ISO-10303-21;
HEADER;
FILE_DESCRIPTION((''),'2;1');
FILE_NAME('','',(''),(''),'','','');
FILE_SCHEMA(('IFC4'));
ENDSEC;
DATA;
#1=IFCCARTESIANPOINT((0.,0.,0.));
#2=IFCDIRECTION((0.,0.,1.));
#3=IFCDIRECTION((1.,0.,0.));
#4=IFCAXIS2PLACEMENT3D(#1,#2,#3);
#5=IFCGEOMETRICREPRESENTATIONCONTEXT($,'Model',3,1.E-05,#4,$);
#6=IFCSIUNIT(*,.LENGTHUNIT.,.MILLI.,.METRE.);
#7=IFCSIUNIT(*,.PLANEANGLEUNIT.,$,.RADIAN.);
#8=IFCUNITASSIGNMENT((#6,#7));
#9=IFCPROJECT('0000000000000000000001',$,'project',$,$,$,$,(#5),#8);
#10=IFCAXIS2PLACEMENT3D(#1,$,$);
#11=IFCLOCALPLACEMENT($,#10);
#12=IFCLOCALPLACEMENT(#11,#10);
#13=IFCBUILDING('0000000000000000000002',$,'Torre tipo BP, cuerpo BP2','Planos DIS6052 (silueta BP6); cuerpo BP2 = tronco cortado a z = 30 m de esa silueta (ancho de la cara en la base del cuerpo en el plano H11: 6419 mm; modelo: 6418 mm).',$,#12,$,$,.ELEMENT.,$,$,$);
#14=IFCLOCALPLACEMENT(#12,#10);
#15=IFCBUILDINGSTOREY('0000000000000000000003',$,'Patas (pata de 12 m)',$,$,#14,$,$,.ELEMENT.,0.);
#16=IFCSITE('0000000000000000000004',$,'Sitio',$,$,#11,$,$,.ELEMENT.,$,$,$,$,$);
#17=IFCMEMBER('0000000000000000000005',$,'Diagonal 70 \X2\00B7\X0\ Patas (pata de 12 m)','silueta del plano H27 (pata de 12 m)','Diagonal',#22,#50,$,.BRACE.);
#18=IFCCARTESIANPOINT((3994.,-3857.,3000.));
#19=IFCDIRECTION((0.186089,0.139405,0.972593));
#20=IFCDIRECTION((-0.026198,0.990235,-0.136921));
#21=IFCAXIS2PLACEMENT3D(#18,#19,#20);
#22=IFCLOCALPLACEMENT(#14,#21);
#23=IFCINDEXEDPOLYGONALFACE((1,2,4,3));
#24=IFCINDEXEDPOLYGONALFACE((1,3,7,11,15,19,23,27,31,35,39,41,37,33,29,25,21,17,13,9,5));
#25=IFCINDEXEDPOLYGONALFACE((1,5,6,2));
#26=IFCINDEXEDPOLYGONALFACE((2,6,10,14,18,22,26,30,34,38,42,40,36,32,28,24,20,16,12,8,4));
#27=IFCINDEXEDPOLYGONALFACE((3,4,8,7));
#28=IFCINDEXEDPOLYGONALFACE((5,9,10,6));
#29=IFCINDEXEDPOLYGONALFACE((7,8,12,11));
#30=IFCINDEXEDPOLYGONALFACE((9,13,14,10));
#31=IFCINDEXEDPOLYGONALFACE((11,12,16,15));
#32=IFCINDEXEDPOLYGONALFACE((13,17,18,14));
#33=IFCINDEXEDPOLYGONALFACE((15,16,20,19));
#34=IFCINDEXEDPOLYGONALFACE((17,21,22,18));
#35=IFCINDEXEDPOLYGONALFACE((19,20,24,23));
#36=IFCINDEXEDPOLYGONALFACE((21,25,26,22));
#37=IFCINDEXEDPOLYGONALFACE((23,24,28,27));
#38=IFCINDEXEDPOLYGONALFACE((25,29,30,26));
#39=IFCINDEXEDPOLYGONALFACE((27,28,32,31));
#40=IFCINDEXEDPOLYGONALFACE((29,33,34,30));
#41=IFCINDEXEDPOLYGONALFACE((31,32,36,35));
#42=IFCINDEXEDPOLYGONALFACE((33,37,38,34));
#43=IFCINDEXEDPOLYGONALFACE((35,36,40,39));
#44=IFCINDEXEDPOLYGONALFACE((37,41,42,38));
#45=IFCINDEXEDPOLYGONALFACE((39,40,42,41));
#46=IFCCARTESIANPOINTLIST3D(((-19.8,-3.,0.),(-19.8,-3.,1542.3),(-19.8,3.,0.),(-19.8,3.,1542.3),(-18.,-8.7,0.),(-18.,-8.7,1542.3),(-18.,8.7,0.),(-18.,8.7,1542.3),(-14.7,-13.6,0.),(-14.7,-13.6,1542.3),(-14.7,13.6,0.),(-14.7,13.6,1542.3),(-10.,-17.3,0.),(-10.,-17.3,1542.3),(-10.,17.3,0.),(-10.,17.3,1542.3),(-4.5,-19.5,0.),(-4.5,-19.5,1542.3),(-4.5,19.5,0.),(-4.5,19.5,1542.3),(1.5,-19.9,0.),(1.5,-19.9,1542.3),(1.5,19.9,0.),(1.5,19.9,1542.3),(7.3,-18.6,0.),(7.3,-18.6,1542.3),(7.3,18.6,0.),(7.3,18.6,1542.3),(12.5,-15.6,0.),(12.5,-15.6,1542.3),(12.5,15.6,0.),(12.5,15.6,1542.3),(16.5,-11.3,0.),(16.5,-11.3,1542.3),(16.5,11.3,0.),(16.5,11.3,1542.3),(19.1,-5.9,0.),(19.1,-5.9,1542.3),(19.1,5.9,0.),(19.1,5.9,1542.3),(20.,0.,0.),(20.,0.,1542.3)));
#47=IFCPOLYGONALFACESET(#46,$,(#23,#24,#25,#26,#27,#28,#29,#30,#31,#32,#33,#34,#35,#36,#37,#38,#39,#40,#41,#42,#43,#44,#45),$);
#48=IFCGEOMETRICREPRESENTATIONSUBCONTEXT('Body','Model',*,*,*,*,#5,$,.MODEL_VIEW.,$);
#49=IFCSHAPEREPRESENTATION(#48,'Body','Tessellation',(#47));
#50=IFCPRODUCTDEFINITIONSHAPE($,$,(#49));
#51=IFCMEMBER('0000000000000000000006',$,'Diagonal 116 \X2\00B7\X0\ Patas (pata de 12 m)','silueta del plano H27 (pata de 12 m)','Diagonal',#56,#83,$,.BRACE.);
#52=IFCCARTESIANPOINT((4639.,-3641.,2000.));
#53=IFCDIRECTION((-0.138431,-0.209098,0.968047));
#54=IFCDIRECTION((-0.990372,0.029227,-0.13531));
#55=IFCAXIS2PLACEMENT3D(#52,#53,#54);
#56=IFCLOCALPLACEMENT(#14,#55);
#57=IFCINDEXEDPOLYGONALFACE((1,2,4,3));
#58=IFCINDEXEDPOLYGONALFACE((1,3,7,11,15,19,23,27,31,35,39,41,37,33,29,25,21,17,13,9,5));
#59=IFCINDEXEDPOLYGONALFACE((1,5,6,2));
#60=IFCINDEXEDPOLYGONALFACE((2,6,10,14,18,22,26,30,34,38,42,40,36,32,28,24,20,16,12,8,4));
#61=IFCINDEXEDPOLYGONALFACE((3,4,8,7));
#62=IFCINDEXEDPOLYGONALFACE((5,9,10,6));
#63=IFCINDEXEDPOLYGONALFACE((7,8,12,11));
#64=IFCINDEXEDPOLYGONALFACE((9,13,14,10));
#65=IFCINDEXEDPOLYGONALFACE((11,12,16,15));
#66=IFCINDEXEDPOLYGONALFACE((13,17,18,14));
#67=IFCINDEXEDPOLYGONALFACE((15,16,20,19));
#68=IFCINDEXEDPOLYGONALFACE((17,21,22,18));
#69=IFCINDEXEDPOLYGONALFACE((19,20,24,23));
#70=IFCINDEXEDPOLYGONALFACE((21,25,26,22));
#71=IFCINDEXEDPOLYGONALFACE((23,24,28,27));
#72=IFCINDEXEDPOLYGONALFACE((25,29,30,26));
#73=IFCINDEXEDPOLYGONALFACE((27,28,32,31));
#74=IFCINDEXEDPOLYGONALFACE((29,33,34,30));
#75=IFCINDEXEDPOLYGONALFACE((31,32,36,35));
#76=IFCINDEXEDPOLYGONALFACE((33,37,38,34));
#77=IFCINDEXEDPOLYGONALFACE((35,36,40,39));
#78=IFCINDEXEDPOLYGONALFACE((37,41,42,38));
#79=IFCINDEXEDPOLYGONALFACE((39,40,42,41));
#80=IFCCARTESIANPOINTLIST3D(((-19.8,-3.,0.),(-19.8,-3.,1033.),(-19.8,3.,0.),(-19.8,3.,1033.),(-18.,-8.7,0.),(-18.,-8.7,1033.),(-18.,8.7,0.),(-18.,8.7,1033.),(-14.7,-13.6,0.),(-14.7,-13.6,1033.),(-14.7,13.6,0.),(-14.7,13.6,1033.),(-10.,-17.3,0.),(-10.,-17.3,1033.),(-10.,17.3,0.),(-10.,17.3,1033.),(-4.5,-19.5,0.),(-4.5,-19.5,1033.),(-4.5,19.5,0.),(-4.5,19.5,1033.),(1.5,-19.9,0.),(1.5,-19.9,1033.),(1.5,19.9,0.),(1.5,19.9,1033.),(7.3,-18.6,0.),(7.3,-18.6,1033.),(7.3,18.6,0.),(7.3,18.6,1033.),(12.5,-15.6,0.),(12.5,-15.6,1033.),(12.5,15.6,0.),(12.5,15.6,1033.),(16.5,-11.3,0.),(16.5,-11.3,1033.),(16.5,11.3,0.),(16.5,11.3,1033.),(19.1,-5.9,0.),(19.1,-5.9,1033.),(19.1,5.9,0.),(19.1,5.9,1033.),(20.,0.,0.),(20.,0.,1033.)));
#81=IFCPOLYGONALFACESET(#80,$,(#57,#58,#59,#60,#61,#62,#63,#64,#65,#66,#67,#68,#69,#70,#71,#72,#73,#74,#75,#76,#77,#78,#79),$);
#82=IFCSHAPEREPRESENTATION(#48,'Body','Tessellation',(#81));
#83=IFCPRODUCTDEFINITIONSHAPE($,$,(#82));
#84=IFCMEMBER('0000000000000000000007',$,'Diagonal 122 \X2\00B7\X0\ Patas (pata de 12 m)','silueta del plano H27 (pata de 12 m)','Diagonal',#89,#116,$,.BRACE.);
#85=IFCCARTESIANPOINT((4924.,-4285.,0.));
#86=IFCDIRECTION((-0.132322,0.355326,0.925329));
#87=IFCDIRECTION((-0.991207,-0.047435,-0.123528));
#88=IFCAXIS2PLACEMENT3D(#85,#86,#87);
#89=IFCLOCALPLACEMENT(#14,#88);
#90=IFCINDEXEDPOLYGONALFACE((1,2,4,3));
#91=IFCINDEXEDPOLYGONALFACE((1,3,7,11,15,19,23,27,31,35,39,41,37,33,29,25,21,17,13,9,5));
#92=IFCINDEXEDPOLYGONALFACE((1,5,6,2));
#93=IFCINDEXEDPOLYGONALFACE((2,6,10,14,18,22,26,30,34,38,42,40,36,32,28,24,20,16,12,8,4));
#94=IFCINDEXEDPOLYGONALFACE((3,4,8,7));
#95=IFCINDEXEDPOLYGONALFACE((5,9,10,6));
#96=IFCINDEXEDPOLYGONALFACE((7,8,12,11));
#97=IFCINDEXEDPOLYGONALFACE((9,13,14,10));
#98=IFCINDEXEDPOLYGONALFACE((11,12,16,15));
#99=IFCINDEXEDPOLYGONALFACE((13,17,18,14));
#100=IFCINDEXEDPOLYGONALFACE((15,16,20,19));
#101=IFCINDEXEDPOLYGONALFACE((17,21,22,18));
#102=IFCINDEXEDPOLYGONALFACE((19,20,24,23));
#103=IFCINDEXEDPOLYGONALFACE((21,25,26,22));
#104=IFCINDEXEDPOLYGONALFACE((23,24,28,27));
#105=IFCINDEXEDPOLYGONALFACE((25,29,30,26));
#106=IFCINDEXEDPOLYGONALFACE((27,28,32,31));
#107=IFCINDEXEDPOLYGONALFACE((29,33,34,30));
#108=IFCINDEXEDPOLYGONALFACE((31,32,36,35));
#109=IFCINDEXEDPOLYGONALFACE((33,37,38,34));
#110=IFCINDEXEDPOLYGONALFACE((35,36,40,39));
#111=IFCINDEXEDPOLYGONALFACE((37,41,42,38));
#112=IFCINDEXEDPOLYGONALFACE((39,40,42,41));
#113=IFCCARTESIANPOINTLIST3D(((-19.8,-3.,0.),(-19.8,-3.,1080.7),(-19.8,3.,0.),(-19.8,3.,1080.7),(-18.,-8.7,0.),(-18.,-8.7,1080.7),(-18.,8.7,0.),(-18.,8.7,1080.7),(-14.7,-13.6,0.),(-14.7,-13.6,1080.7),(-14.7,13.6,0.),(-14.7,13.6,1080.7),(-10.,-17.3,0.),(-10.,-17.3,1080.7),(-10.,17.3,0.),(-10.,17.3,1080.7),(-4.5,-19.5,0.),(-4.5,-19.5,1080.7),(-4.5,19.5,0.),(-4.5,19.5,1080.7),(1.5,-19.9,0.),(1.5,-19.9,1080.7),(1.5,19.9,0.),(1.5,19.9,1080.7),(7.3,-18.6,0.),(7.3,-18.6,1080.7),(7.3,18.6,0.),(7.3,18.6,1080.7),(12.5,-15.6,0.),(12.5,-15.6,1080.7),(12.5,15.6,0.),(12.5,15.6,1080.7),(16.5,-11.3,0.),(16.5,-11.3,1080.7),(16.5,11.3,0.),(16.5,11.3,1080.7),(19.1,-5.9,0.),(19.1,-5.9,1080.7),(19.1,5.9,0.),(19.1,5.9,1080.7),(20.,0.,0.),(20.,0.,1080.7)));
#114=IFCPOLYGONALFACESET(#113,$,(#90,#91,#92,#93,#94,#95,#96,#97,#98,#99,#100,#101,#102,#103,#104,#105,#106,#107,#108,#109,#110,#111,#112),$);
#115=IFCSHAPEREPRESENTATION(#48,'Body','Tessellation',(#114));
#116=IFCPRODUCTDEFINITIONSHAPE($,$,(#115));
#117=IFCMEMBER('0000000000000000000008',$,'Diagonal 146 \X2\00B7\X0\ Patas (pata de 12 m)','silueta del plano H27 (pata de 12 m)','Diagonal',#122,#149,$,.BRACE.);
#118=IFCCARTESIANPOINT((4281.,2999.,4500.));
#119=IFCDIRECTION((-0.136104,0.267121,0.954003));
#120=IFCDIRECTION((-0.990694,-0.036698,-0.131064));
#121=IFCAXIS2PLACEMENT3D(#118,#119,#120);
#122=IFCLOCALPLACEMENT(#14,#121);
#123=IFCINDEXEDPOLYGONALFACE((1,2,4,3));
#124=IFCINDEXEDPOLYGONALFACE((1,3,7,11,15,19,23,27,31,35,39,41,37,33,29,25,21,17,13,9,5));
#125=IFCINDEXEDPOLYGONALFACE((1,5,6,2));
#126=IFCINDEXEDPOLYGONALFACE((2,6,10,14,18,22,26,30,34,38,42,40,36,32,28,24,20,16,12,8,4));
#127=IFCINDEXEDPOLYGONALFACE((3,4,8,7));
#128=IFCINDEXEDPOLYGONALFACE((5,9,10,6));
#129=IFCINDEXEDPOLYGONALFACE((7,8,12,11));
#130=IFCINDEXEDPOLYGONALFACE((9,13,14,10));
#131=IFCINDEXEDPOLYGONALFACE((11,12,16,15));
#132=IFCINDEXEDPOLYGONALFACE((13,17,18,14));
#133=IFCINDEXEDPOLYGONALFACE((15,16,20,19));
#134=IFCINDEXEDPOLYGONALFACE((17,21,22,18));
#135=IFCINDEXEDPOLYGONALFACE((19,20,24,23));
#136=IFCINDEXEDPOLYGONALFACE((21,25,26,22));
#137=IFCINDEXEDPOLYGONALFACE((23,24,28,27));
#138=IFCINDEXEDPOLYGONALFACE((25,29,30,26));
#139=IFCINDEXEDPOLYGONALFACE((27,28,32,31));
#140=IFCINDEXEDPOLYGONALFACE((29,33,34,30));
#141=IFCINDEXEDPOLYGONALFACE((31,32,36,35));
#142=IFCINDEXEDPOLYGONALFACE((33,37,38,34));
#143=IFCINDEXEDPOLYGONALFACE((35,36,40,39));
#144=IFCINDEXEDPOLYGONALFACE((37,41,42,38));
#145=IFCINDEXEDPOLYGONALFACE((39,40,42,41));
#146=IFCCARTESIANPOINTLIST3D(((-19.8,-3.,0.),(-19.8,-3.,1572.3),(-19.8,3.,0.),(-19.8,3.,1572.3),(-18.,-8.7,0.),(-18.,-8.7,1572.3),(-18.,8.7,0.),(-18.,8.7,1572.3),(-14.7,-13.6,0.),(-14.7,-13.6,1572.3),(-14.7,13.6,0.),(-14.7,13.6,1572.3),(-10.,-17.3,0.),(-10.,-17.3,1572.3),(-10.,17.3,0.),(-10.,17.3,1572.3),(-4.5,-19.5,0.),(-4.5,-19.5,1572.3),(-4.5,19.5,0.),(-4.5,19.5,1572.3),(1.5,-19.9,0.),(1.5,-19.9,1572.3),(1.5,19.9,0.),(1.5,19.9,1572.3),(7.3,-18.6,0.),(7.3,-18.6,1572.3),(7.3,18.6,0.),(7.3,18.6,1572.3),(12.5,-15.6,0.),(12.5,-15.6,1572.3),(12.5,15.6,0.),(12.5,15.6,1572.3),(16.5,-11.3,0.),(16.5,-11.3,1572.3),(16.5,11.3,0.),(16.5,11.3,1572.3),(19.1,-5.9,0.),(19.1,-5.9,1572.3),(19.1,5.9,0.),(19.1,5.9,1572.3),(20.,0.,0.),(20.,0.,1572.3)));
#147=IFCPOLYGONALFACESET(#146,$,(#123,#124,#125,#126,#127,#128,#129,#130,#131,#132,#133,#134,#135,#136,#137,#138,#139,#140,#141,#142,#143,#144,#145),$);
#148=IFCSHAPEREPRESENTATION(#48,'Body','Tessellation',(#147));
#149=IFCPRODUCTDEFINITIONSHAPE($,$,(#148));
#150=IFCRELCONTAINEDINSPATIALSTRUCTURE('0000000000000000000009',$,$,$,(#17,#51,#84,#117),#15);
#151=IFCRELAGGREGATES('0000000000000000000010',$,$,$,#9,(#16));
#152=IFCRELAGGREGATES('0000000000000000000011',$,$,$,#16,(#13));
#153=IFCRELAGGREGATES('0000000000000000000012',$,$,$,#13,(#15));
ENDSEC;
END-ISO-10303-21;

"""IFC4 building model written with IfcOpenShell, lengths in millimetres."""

from ifc_helpers import new_model, si_unit, frame, origin, origin_with_axes, place, context, subcontext, project, spatial, circle, extrude, element, save


model = new_model("IFC4")

# Units and contexts
model_context = context("Model", 3, precision=1e-05, world=origin_with_axes())
body_context = subcontext(model_context, "Body", "Model", "MODEL_VIEW")
ifc_project = project(units=[si_unit("LENGTHUNIT", "METRE", prefix="MILLI"), si_unit("PLANEANGLEUNIT", "RADIAN")], contexts=[model_context])

# Site, building, storey
site_placement = place(None, origin())
site = spatial("IfcSite", under=ifc_project, at=site_placement, Name="Sitio", CompositionType="ELEMENT")
building_placement = place(site_placement, origin())
building = spatial("IfcBuilding", under=site, at=building_placement, Name="Torre tipo BP, cuerpo BP2", Description="Planos DIS6052 (silueta BP6); cuerpo BP2 = tronco cortado a z = 30 m de esa silueta (ancho de la cara en la base del cuerpo en el plano H11: 6419 mm; modelo: 6418 mm).", CompositionType="ELEMENT")
storey_placement = place(building_placement, origin())
storey = spatial("IfcBuildingStorey", under=building, at=storey_placement, Name="Patas (pata de 12 m)", CompositionType="ELEMENT", Elevation=0.0)

# Members
member_1_placement = place(storey_placement, frame((3994.0, -3857.0, 3000.0), z_axis=(0.186089, 0.139405, 0.972593), x_axis=(-0.026198, 0.990235, -0.136921)))
element("IfcMember", 1, at=member_1_placement, inside=storey, Name="Diagonal 70 · Patas (pata de 12 m)", Description="silueta del plano H27 (pata de 12 m)", ObjectType="Diagonal", PredefinedType="BRACE", context=body_context, shape_type="SweptSolid", body=[
    extrude(circle(Radius=20.0), None, (0.0, 0.0, 1.0), 1542.3),
])
member_2_placement = place(storey_placement, frame((4639.0, -3641.0, 2000.0), z_axis=(-0.138431, -0.209098, 0.968047), x_axis=(-0.990372, 0.029227, -0.13531)))
element("IfcMember", 2, at=member_2_placement, inside=storey, Name="Diagonal 116 · Patas (pata de 12 m)", Description="silueta del plano H27 (pata de 12 m)", ObjectType="Diagonal", PredefinedType="BRACE", context=body_context, shape_type="SweptSolid", body=[
    extrude(circle(Radius=20.0), None, (0.0, 0.0, 1.0), 1033.0),
])
member_3_placement = place(storey_placement, frame((4924.0, -4285.0, 0.0), z_axis=(-0.132322, 0.355326, 0.925329), x_axis=(-0.991207, -0.047435, -0.123528)))
element("IfcMember", 3, at=member_3_placement, inside=storey, Name="Diagonal 122 · Patas (pata de 12 m)", Description="silueta del plano H27 (pata de 12 m)", ObjectType="Diagonal", PredefinedType="BRACE", context=body_context, shape_type="SweptSolid", body=[
    extrude(circle(Radius=20.0), None, (0.0, 0.0, 1.0), 1080.7),
])
member_4_placement = place(storey_placement, frame((4281.0, 2999.0, 4500.0), z_axis=(-0.136104, 0.267121, 0.954003), x_axis=(-0.990694, -0.036698, -0.131064)))
element("IfcMember", 4, at=member_4_placement, inside=storey, Name="Diagonal 146 · Patas (pata de 12 m)", Description="silueta del plano H27 (pata de 12 m)", ObjectType="Diagonal", PredefinedType="BRACE", context=body_context, shape_type="SweptSolid", body=[
    extrude(circle(Radius=20.0), None, (0.0, 0.0, 1.0), 1572.3),
])

save(model, "model.ifc")
